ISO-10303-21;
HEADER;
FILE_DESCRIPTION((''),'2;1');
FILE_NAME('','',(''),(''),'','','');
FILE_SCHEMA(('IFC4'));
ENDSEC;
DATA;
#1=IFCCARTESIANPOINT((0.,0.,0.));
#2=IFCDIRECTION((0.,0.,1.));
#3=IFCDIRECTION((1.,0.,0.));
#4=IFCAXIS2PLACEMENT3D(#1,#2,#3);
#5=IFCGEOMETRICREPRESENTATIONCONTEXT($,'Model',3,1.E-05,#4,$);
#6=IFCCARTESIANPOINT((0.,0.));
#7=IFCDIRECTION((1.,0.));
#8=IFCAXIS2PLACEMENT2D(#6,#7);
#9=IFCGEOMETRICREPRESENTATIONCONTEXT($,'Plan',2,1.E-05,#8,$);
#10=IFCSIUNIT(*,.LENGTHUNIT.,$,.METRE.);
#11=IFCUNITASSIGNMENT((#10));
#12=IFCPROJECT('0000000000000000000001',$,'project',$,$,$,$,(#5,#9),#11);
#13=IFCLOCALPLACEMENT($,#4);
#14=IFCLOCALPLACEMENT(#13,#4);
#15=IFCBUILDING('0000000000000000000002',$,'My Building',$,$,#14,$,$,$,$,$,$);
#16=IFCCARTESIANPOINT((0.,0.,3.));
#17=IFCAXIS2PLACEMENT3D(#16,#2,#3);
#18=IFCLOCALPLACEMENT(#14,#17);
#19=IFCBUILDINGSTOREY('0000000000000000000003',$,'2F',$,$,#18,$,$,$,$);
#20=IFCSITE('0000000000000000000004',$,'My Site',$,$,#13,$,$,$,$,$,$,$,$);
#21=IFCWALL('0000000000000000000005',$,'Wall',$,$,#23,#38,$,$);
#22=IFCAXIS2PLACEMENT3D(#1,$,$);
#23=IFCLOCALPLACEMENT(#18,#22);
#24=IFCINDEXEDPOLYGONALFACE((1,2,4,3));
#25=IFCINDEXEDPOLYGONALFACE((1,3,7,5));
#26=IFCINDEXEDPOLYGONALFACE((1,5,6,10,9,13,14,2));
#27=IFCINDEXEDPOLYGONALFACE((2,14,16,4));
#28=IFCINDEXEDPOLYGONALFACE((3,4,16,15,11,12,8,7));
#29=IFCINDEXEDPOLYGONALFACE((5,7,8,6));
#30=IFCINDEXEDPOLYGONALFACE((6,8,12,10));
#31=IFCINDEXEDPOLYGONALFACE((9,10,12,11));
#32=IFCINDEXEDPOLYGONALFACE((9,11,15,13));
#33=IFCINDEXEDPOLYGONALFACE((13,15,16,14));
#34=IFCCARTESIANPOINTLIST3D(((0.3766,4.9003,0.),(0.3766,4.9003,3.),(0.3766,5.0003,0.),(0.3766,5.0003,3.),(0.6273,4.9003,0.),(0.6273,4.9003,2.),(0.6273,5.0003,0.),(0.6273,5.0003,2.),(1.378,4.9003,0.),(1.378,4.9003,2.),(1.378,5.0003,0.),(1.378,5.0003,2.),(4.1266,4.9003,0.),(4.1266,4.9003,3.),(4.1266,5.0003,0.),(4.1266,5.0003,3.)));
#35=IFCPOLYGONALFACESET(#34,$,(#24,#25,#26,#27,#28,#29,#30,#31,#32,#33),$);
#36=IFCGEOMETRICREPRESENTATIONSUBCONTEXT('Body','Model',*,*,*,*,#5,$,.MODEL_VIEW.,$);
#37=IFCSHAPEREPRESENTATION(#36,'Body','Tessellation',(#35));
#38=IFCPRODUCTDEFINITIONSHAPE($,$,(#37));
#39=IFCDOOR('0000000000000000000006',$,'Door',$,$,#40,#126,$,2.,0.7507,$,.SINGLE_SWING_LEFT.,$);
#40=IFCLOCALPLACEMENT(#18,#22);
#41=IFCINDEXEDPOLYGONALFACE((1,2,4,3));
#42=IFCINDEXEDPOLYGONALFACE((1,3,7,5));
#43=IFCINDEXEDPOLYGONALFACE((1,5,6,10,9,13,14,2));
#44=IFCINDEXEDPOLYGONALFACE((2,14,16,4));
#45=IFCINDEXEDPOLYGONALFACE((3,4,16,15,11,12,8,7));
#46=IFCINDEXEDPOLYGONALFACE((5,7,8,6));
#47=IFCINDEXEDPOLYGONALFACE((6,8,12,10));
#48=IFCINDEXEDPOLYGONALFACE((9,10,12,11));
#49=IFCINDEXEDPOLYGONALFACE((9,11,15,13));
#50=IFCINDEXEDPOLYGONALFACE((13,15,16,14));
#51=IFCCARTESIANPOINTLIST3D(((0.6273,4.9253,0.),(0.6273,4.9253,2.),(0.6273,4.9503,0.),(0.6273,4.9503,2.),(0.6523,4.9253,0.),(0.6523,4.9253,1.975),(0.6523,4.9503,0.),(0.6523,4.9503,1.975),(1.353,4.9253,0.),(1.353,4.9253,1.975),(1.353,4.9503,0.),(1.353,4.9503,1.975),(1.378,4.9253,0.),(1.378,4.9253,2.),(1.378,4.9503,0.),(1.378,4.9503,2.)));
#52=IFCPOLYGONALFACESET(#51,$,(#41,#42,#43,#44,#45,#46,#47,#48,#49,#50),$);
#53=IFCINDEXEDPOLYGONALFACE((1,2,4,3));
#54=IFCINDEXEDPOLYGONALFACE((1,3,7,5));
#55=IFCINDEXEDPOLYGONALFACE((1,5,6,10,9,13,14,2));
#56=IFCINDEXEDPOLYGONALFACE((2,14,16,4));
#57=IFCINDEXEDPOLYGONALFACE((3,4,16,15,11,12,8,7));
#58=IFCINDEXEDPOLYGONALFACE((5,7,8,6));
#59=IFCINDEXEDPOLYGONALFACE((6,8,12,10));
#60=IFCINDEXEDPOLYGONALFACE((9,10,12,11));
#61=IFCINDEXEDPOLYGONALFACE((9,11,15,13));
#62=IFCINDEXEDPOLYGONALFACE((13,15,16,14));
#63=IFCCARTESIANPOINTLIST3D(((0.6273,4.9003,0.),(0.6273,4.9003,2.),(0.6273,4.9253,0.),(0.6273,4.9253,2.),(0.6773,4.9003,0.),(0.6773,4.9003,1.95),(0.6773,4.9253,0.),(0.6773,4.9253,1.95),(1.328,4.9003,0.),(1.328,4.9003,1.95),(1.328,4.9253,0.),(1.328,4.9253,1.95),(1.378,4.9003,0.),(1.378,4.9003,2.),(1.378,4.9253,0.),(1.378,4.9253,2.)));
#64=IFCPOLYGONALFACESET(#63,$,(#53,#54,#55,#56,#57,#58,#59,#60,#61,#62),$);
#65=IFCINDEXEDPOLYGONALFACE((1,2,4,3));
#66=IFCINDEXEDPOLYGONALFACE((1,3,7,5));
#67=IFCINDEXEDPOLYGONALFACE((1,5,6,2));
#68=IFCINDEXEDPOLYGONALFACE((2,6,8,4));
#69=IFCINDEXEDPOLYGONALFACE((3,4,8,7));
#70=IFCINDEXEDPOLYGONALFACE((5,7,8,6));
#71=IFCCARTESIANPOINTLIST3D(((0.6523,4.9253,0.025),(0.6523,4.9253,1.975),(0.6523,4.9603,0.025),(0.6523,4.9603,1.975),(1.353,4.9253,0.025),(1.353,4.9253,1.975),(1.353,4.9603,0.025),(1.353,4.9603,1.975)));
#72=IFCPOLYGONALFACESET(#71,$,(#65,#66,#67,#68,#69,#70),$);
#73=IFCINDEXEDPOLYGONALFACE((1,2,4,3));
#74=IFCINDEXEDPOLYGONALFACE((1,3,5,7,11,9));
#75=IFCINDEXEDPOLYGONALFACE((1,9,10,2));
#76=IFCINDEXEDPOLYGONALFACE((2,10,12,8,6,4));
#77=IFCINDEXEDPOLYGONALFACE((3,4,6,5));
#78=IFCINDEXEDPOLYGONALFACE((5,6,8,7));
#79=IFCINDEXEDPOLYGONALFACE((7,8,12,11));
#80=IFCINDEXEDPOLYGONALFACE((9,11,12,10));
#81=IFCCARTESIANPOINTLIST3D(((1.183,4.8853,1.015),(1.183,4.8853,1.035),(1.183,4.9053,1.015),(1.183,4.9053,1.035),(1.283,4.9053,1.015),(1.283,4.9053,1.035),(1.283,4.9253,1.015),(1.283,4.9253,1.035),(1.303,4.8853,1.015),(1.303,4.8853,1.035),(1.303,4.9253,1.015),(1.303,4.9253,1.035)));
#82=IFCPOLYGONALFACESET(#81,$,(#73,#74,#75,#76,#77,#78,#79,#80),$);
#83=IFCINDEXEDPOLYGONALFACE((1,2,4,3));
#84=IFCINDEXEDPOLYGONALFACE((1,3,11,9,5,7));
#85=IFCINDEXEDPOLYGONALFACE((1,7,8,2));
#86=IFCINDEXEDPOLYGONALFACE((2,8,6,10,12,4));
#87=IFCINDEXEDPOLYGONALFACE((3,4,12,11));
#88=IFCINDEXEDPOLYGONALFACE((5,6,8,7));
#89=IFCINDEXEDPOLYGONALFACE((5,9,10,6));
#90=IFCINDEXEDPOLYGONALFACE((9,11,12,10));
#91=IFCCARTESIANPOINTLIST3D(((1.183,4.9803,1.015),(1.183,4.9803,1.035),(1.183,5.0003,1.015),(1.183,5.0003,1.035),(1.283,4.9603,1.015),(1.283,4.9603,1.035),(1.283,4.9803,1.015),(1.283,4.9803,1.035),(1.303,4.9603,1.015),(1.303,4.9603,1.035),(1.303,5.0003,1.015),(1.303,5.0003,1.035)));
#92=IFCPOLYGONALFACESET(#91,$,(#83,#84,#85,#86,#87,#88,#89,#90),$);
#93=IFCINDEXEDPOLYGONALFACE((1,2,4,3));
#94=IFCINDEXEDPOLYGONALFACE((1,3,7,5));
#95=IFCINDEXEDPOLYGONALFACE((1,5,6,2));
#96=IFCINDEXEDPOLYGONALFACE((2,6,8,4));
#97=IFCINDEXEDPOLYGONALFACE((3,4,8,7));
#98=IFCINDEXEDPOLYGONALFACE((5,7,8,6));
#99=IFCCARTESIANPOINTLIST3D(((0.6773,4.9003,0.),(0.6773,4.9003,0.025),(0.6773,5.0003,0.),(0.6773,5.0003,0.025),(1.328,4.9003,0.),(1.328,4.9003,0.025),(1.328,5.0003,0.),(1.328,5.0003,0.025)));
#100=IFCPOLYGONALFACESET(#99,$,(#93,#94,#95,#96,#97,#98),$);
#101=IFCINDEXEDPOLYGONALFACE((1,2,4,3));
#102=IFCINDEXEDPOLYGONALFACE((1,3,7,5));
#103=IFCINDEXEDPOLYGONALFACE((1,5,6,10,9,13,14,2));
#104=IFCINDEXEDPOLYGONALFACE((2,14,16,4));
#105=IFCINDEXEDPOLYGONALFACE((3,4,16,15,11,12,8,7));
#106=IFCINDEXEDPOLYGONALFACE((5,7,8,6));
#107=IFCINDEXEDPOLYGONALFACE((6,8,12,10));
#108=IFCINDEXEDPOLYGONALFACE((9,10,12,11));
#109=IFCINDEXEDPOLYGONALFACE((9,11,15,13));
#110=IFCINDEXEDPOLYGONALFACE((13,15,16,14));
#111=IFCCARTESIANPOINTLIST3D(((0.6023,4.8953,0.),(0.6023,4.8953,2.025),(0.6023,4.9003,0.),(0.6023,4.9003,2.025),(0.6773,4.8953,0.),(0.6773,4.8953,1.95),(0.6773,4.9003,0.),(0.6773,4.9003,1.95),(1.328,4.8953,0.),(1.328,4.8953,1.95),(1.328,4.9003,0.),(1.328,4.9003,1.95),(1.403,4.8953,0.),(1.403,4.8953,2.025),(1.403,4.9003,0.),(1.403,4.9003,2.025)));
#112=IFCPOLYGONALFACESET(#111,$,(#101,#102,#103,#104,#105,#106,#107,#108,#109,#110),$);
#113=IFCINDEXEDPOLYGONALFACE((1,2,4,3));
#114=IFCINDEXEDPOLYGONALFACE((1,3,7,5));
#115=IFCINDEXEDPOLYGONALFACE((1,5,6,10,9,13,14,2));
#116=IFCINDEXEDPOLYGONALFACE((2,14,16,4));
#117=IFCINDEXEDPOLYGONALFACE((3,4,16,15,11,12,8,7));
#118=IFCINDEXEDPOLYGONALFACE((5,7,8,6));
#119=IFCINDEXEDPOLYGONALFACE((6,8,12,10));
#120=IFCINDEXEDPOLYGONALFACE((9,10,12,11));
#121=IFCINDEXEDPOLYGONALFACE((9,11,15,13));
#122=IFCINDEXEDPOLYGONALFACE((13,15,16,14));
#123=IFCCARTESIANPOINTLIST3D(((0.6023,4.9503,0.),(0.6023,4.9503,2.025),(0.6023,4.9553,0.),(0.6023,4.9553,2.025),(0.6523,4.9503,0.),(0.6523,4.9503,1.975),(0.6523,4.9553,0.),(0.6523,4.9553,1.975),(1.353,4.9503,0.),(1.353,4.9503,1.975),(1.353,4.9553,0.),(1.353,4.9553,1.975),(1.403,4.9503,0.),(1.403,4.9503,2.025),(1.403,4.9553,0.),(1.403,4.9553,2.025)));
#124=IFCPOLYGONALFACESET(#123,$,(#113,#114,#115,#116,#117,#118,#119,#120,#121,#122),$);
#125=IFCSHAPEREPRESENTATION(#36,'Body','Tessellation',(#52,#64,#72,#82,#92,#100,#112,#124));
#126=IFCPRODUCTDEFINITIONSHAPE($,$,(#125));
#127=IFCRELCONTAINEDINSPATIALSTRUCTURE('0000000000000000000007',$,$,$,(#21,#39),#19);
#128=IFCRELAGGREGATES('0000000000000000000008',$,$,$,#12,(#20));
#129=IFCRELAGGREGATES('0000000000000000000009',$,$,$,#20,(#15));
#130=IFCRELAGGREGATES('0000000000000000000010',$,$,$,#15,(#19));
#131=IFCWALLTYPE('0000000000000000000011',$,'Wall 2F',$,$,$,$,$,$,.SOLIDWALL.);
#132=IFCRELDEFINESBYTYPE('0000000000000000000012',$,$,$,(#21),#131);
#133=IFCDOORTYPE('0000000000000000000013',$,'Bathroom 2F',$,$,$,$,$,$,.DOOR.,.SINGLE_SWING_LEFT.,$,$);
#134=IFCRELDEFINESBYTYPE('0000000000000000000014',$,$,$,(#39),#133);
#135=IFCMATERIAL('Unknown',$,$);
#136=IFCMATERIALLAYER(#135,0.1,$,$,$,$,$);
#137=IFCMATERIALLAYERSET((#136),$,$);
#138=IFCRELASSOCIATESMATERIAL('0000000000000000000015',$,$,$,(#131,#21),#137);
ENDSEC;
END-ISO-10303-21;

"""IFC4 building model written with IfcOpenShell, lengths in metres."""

from ifc_helpers import new_model, entity, si_unit, frame, origin_with_axes, origin_2d_with_axis, place, context, subcontext, project, spatial, line, indexed_curve, outline, extrude, shape, source, transform, mapped, material, layer, layer_set, layer_usage, type_object, type_shapes, element, fill, save


model = new_model("IFC4")

# Units and contexts
model_context = context("Model", 3, precision=1e-05, world=origin_with_axes())
plan_context = context("Plan", 2, precision=1e-05, world=origin_2d_with_axis())
body_context_1 = subcontext(model_context, "Body", "Model", "MODEL_VIEW")
body_context_2 = subcontext(plan_context, "Body", "Plan", "PLAN_VIEW")
ifc_project = project(units=[si_unit("LENGTHUNIT", "METRE")], contexts=[model_context, plan_context])

# Site, building, storey
site_placement = place(None, origin_with_axes())
site = spatial("IfcSite", under=ifc_project, at=site_placement, Name="My Site")
building_placement = place(site_placement, origin_with_axes())
building = spatial("IfcBuilding", under=site, at=building_placement, Name="My Building")
storey_placement = place(building_placement, frame((0.0, 0.0, 3.0), z_axis=(0.0, 0.0, 1.0), x_axis=(1.0, 0.0, 0.0)))
storey = spatial("IfcBuildingStorey", under=building, at=storey_placement, Name="2F")

# Shared definitions
ifc_material = material(Name="Unknown")

# Shared definitions
ifc_layer = layer(ifc_material, 0.1)
ifc_layer_set = layer_set([ifc_layer])
wall_type = type_object("IfcWallType", Name="Wall 2F", PredefinedType="SOLIDWALL", material=ifc_layer_set)

# Wall, opening, door
ifc_layer_usage_1 = layer_usage(ifc_layer_set, "AXIS2", "POSITIVE", 0.0)
wall_1_placement = place(storey_placement, frame((4.2266, 5.0003, 0.0), z_axis=(0.0, 0.0, 1.0), x_axis=(-1.0, 0.0, 0.0)))
wall_1 = element("IfcWall", 1, at=wall_1_placement, inside=storey, type_object=wall_type, material=ifc_layer_usage_1, Name="Wall", context=body_context_1, shape_type="SweptSolid", body=[
    extrude(outline(indexed_curve([(0.1, 0.0), (0.1, 0.1), (3.85, 0.1), (3.85, 0.0)], segments=[line(1, 2, 3, 4, 1)])), origin_with_axes(), (0.0, 0.0, 1.0), 3.0),
])
shared_shape_1 = source(origin_with_axes(), body_context_1, "Body", "SweptSolid", [
    extrude(outline(indexed_curve([(0.0, 0.0), (0.7507, 0.0), (0.7507, 2.0), (0.0, 2.0)], segments=[line(1, 2, 3, 4, 1)])), frame((0.0, -0.6, 0.0), z_axis=(0.0, -1.0, 0.0), x_axis=(1.0, 0.0, 0.0)), (0.0, 0.0, -1.0), 1.2),
])
opening_1_placement = place(wall_1_placement, frame((3.5993, 0.1, 0.0), z_axis=(0.0, 0.0, 1.0), x_axis=(-1.0, 0.000001, 0.0)))
opening_1 = element("IfcOpeningElement", 2, at=opening_1_placement, cuts=wall_1, PredefinedType="OPENING", context=body_context_1, shape_type="MappedRepresentation", body=[
    mapped(shared_shape_1, transform((0.0, 0.0, 0.0), x_axis=(1.0, 0.0, 0.0), y_axis=(0.0, 1.0, 0.0), z_axis=(0.0, 0.0, 1.0), scale=1.0)),
])
door_type_1 = type_object("IfcDoorType", Name="Bathroom 2F", OperationType="SINGLE_SWING_LEFT", PredefinedType="DOOR")
shared_shape_2 = source(origin_with_axes(), body_context_1, "Body", "SweptSolid", [
    extrude(outline(indexed_curve([(0.0, 0.0), (0.0, 2.0), (0.7507, 2.0), (0.7507, 0.0), (0.7257, 0.0), (0.7257, 1.975), (0.025, 1.975), (0.025, 0.0)], segments=[line(1, 2, 3, 4, 5, 6, 7, 8, 1)])), frame((0.0, 0.025, 0.0), z_axis=(0.0, -1.0, 0.0), x_axis=(1.0, 0.0, 0.0)), (0.0, 0.0, -1.0), 0.025),
    extrude(outline(indexed_curve([(0.0, 0.0), (0.0, 2.0), (0.7507, 2.0), (0.7507, 0.0), (0.7007, 0.0), (0.7007, 1.95), (0.05, 1.95), (0.05, 0.0)], segments=[line(1, 2, 3, 4, 5, 6, 7, 8, 1)])), frame((0.0, 0.0, 0.0), z_axis=(0.0, -1.0, 0.0), x_axis=(1.0, 0.0, 0.0)), (0.0, 0.0, -1.0), 0.025),
    extrude(outline(indexed_curve([(0.0, 0.0), (0.7007, 0.0), (0.7007, 0.035), (0.0, 0.035)], segments=[line(1, 2, 3, 4, 1)])), frame((0.025, 0.025, 0.025), z_axis=(0.0, 0.0, 1.0), x_axis=(1.0, 0.0, 0.0)), (0.0, 0.0, 1.0), 1.95),
    extrude(outline(indexed_curve([(0.0, 0.0), (0.0, -0.04), (-0.12, -0.04), (-0.12, -0.02), (-0.02, -0.02), (-0.02, 0.0)], segments=[line(1, 2, 3, 4, 5, 6, 1)])), frame((0.6757, 0.025, 1.015), z_axis=(0.0, 0.0, 1.0), x_axis=(1.0, 0.0, 0.0)), (0.0, 0.0, 1.0), 0.02),
    extrude(outline(indexed_curve([(0.0, 0.0), (0.0, 0.04), (-0.12, 0.04), (-0.12, 0.02), (-0.02, 0.02), (-0.02, 0.0)], segments=[line(1, 2, 3, 4, 5, 6, 1)])), frame((0.6757, 0.06, 1.015), z_axis=(0.0, 0.0, 1.0), x_axis=(1.0, 0.0, 0.0)), (0.0, 0.0, 1.0), 0.02),
    extrude(outline(indexed_curve([(0.0, 0.0), (0.6507, 0.0), (0.6507, 0.1), (0.0, 0.1)], segments=[line(1, 2, 3, 4, 1)])), frame((0.05, 0.0, 0.0), z_axis=(0.0, 0.0, 1.0), x_axis=(1.0, 0.0, 0.0)), (0.0, 0.0, 1.0), 0.025),
    extrude(outline(indexed_curve([(0.0, 0.0), (0.0, 2.025), (0.8007, 2.025), (0.8007, 0.0), (0.7257, 0.0), (0.7257, 1.95), (0.075, 1.95), (0.075, 0.0)], segments=[line(1, 2, 3, 4, 5, 6, 7, 8, 1)])), frame((-0.025, -0.005, 0.0), z_axis=(0.0, -1.0, 0.0), x_axis=(1.0, 0.0, 0.0)), (0.0, 0.0, -1.0), 0.005),
    extrude(outline(indexed_curve([(0.0, 0.0), (0.0, 2.025), (0.8007, 2.025), (0.8007, 0.0), (0.7507, 0.0), (0.7507, 1.975), (0.05, 1.975), (0.05, 0.0)], segments=[line(1, 2, 3, 4, 5, 6, 7, 8, 1)])), frame((-0.025, 0.05, 0.0), z_axis=(0.0, -1.0, 0.0), x_axis=(1.0, 0.0, 0.0)), (0.0, 0.0, -1.0), 0.005),
])
shared_shape_3 = source(origin_with_axes(), body_context_2, "Body", "Curve2D", [
    entity("IfcIndexedPolyCurve", entity("IfcCartesianPointList2D", [[0.0, 0.0], [0.0, 0.05], [0.025, 0.05], [0.025, 0.025], [0.05, 0.025], [0.05, 0.0]]), [entity("IfcLineIndex", [1, 2, 3, 4, 5, 6, 1])]),
    entity("IfcIndexedPolyCurve", entity("IfcCartesianPointList2D", [[0.7507, 0.0], [0.7507, 0.05], [0.7257, 0.05], [0.7257, 0.025], [0.7007, 0.025], [0.7007, 0.0]]), [entity("IfcLineIndex", [1, 2, 3, 4, 5, 6, 1])]),
    entity("IfcTrimmedCurve", entity("IfcEllipse", entity("IfcAxis2Placement2D", entity("IfcCartesianPoint", [0.06, 0.05]), entity("IfcDirection", [1.0, 0.0])), 0.6657, 0.7007), [entity("IfcCartesianPoint", [0.7257, 0.05])], [entity("IfcCartesianPoint", [0.06, 0.7507])], True, "CARTESIAN"),
    entity("IfcIndexedPolyCurve", entity("IfcCartesianPointList2D", [[0.025, 0.05], [0.06, 0.05], [0.06, 0.7507], [0.025, 0.7507]]), [entity("IfcLineIndex", [1, 2, 3, 4, 1])]),
])
type_shapes(door_type_1, [shared_shape_2, shared_shape_3])
door_1_placement = place(opening_1_placement, frame((0.0, 0.0, 0.0), z_axis=(0.0, 0.0, 1.0), x_axis=(1.0, 0.0, 0.0)))
door_1 = element("IfcDoor", 3, at=door_1_placement, inside=storey, type_object=door_type_1, Name="Door", OperationType="SINGLE_SWING_LEFT", OverallHeight=2.0, OverallWidth=0.7507, shapes=[
    shape(body_context_1, "Body", "MappedRepresentation", [mapped(shared_shape_2, transform((0.0, 0.0, 0.0), x_axis=(1.0, 0.0, 0.0), y_axis=(0.0, 1.0, 0.0), z_axis=(0.0, 0.0, 1.0), scale=1.0))]),
    shape(body_context_2, "Body", "MappedRepresentation", [mapped(shared_shape_3, transform((0.0, 0.0, 0.0), x_axis=(1.0, 0.0, 0.0), y_axis=(0.0, 1.0, 0.0), z_axis=(0.0, 0.0, 1.0), scale=1.0))]),
])
fill(opening_1, door_1)

save(model, "model.ifc")
